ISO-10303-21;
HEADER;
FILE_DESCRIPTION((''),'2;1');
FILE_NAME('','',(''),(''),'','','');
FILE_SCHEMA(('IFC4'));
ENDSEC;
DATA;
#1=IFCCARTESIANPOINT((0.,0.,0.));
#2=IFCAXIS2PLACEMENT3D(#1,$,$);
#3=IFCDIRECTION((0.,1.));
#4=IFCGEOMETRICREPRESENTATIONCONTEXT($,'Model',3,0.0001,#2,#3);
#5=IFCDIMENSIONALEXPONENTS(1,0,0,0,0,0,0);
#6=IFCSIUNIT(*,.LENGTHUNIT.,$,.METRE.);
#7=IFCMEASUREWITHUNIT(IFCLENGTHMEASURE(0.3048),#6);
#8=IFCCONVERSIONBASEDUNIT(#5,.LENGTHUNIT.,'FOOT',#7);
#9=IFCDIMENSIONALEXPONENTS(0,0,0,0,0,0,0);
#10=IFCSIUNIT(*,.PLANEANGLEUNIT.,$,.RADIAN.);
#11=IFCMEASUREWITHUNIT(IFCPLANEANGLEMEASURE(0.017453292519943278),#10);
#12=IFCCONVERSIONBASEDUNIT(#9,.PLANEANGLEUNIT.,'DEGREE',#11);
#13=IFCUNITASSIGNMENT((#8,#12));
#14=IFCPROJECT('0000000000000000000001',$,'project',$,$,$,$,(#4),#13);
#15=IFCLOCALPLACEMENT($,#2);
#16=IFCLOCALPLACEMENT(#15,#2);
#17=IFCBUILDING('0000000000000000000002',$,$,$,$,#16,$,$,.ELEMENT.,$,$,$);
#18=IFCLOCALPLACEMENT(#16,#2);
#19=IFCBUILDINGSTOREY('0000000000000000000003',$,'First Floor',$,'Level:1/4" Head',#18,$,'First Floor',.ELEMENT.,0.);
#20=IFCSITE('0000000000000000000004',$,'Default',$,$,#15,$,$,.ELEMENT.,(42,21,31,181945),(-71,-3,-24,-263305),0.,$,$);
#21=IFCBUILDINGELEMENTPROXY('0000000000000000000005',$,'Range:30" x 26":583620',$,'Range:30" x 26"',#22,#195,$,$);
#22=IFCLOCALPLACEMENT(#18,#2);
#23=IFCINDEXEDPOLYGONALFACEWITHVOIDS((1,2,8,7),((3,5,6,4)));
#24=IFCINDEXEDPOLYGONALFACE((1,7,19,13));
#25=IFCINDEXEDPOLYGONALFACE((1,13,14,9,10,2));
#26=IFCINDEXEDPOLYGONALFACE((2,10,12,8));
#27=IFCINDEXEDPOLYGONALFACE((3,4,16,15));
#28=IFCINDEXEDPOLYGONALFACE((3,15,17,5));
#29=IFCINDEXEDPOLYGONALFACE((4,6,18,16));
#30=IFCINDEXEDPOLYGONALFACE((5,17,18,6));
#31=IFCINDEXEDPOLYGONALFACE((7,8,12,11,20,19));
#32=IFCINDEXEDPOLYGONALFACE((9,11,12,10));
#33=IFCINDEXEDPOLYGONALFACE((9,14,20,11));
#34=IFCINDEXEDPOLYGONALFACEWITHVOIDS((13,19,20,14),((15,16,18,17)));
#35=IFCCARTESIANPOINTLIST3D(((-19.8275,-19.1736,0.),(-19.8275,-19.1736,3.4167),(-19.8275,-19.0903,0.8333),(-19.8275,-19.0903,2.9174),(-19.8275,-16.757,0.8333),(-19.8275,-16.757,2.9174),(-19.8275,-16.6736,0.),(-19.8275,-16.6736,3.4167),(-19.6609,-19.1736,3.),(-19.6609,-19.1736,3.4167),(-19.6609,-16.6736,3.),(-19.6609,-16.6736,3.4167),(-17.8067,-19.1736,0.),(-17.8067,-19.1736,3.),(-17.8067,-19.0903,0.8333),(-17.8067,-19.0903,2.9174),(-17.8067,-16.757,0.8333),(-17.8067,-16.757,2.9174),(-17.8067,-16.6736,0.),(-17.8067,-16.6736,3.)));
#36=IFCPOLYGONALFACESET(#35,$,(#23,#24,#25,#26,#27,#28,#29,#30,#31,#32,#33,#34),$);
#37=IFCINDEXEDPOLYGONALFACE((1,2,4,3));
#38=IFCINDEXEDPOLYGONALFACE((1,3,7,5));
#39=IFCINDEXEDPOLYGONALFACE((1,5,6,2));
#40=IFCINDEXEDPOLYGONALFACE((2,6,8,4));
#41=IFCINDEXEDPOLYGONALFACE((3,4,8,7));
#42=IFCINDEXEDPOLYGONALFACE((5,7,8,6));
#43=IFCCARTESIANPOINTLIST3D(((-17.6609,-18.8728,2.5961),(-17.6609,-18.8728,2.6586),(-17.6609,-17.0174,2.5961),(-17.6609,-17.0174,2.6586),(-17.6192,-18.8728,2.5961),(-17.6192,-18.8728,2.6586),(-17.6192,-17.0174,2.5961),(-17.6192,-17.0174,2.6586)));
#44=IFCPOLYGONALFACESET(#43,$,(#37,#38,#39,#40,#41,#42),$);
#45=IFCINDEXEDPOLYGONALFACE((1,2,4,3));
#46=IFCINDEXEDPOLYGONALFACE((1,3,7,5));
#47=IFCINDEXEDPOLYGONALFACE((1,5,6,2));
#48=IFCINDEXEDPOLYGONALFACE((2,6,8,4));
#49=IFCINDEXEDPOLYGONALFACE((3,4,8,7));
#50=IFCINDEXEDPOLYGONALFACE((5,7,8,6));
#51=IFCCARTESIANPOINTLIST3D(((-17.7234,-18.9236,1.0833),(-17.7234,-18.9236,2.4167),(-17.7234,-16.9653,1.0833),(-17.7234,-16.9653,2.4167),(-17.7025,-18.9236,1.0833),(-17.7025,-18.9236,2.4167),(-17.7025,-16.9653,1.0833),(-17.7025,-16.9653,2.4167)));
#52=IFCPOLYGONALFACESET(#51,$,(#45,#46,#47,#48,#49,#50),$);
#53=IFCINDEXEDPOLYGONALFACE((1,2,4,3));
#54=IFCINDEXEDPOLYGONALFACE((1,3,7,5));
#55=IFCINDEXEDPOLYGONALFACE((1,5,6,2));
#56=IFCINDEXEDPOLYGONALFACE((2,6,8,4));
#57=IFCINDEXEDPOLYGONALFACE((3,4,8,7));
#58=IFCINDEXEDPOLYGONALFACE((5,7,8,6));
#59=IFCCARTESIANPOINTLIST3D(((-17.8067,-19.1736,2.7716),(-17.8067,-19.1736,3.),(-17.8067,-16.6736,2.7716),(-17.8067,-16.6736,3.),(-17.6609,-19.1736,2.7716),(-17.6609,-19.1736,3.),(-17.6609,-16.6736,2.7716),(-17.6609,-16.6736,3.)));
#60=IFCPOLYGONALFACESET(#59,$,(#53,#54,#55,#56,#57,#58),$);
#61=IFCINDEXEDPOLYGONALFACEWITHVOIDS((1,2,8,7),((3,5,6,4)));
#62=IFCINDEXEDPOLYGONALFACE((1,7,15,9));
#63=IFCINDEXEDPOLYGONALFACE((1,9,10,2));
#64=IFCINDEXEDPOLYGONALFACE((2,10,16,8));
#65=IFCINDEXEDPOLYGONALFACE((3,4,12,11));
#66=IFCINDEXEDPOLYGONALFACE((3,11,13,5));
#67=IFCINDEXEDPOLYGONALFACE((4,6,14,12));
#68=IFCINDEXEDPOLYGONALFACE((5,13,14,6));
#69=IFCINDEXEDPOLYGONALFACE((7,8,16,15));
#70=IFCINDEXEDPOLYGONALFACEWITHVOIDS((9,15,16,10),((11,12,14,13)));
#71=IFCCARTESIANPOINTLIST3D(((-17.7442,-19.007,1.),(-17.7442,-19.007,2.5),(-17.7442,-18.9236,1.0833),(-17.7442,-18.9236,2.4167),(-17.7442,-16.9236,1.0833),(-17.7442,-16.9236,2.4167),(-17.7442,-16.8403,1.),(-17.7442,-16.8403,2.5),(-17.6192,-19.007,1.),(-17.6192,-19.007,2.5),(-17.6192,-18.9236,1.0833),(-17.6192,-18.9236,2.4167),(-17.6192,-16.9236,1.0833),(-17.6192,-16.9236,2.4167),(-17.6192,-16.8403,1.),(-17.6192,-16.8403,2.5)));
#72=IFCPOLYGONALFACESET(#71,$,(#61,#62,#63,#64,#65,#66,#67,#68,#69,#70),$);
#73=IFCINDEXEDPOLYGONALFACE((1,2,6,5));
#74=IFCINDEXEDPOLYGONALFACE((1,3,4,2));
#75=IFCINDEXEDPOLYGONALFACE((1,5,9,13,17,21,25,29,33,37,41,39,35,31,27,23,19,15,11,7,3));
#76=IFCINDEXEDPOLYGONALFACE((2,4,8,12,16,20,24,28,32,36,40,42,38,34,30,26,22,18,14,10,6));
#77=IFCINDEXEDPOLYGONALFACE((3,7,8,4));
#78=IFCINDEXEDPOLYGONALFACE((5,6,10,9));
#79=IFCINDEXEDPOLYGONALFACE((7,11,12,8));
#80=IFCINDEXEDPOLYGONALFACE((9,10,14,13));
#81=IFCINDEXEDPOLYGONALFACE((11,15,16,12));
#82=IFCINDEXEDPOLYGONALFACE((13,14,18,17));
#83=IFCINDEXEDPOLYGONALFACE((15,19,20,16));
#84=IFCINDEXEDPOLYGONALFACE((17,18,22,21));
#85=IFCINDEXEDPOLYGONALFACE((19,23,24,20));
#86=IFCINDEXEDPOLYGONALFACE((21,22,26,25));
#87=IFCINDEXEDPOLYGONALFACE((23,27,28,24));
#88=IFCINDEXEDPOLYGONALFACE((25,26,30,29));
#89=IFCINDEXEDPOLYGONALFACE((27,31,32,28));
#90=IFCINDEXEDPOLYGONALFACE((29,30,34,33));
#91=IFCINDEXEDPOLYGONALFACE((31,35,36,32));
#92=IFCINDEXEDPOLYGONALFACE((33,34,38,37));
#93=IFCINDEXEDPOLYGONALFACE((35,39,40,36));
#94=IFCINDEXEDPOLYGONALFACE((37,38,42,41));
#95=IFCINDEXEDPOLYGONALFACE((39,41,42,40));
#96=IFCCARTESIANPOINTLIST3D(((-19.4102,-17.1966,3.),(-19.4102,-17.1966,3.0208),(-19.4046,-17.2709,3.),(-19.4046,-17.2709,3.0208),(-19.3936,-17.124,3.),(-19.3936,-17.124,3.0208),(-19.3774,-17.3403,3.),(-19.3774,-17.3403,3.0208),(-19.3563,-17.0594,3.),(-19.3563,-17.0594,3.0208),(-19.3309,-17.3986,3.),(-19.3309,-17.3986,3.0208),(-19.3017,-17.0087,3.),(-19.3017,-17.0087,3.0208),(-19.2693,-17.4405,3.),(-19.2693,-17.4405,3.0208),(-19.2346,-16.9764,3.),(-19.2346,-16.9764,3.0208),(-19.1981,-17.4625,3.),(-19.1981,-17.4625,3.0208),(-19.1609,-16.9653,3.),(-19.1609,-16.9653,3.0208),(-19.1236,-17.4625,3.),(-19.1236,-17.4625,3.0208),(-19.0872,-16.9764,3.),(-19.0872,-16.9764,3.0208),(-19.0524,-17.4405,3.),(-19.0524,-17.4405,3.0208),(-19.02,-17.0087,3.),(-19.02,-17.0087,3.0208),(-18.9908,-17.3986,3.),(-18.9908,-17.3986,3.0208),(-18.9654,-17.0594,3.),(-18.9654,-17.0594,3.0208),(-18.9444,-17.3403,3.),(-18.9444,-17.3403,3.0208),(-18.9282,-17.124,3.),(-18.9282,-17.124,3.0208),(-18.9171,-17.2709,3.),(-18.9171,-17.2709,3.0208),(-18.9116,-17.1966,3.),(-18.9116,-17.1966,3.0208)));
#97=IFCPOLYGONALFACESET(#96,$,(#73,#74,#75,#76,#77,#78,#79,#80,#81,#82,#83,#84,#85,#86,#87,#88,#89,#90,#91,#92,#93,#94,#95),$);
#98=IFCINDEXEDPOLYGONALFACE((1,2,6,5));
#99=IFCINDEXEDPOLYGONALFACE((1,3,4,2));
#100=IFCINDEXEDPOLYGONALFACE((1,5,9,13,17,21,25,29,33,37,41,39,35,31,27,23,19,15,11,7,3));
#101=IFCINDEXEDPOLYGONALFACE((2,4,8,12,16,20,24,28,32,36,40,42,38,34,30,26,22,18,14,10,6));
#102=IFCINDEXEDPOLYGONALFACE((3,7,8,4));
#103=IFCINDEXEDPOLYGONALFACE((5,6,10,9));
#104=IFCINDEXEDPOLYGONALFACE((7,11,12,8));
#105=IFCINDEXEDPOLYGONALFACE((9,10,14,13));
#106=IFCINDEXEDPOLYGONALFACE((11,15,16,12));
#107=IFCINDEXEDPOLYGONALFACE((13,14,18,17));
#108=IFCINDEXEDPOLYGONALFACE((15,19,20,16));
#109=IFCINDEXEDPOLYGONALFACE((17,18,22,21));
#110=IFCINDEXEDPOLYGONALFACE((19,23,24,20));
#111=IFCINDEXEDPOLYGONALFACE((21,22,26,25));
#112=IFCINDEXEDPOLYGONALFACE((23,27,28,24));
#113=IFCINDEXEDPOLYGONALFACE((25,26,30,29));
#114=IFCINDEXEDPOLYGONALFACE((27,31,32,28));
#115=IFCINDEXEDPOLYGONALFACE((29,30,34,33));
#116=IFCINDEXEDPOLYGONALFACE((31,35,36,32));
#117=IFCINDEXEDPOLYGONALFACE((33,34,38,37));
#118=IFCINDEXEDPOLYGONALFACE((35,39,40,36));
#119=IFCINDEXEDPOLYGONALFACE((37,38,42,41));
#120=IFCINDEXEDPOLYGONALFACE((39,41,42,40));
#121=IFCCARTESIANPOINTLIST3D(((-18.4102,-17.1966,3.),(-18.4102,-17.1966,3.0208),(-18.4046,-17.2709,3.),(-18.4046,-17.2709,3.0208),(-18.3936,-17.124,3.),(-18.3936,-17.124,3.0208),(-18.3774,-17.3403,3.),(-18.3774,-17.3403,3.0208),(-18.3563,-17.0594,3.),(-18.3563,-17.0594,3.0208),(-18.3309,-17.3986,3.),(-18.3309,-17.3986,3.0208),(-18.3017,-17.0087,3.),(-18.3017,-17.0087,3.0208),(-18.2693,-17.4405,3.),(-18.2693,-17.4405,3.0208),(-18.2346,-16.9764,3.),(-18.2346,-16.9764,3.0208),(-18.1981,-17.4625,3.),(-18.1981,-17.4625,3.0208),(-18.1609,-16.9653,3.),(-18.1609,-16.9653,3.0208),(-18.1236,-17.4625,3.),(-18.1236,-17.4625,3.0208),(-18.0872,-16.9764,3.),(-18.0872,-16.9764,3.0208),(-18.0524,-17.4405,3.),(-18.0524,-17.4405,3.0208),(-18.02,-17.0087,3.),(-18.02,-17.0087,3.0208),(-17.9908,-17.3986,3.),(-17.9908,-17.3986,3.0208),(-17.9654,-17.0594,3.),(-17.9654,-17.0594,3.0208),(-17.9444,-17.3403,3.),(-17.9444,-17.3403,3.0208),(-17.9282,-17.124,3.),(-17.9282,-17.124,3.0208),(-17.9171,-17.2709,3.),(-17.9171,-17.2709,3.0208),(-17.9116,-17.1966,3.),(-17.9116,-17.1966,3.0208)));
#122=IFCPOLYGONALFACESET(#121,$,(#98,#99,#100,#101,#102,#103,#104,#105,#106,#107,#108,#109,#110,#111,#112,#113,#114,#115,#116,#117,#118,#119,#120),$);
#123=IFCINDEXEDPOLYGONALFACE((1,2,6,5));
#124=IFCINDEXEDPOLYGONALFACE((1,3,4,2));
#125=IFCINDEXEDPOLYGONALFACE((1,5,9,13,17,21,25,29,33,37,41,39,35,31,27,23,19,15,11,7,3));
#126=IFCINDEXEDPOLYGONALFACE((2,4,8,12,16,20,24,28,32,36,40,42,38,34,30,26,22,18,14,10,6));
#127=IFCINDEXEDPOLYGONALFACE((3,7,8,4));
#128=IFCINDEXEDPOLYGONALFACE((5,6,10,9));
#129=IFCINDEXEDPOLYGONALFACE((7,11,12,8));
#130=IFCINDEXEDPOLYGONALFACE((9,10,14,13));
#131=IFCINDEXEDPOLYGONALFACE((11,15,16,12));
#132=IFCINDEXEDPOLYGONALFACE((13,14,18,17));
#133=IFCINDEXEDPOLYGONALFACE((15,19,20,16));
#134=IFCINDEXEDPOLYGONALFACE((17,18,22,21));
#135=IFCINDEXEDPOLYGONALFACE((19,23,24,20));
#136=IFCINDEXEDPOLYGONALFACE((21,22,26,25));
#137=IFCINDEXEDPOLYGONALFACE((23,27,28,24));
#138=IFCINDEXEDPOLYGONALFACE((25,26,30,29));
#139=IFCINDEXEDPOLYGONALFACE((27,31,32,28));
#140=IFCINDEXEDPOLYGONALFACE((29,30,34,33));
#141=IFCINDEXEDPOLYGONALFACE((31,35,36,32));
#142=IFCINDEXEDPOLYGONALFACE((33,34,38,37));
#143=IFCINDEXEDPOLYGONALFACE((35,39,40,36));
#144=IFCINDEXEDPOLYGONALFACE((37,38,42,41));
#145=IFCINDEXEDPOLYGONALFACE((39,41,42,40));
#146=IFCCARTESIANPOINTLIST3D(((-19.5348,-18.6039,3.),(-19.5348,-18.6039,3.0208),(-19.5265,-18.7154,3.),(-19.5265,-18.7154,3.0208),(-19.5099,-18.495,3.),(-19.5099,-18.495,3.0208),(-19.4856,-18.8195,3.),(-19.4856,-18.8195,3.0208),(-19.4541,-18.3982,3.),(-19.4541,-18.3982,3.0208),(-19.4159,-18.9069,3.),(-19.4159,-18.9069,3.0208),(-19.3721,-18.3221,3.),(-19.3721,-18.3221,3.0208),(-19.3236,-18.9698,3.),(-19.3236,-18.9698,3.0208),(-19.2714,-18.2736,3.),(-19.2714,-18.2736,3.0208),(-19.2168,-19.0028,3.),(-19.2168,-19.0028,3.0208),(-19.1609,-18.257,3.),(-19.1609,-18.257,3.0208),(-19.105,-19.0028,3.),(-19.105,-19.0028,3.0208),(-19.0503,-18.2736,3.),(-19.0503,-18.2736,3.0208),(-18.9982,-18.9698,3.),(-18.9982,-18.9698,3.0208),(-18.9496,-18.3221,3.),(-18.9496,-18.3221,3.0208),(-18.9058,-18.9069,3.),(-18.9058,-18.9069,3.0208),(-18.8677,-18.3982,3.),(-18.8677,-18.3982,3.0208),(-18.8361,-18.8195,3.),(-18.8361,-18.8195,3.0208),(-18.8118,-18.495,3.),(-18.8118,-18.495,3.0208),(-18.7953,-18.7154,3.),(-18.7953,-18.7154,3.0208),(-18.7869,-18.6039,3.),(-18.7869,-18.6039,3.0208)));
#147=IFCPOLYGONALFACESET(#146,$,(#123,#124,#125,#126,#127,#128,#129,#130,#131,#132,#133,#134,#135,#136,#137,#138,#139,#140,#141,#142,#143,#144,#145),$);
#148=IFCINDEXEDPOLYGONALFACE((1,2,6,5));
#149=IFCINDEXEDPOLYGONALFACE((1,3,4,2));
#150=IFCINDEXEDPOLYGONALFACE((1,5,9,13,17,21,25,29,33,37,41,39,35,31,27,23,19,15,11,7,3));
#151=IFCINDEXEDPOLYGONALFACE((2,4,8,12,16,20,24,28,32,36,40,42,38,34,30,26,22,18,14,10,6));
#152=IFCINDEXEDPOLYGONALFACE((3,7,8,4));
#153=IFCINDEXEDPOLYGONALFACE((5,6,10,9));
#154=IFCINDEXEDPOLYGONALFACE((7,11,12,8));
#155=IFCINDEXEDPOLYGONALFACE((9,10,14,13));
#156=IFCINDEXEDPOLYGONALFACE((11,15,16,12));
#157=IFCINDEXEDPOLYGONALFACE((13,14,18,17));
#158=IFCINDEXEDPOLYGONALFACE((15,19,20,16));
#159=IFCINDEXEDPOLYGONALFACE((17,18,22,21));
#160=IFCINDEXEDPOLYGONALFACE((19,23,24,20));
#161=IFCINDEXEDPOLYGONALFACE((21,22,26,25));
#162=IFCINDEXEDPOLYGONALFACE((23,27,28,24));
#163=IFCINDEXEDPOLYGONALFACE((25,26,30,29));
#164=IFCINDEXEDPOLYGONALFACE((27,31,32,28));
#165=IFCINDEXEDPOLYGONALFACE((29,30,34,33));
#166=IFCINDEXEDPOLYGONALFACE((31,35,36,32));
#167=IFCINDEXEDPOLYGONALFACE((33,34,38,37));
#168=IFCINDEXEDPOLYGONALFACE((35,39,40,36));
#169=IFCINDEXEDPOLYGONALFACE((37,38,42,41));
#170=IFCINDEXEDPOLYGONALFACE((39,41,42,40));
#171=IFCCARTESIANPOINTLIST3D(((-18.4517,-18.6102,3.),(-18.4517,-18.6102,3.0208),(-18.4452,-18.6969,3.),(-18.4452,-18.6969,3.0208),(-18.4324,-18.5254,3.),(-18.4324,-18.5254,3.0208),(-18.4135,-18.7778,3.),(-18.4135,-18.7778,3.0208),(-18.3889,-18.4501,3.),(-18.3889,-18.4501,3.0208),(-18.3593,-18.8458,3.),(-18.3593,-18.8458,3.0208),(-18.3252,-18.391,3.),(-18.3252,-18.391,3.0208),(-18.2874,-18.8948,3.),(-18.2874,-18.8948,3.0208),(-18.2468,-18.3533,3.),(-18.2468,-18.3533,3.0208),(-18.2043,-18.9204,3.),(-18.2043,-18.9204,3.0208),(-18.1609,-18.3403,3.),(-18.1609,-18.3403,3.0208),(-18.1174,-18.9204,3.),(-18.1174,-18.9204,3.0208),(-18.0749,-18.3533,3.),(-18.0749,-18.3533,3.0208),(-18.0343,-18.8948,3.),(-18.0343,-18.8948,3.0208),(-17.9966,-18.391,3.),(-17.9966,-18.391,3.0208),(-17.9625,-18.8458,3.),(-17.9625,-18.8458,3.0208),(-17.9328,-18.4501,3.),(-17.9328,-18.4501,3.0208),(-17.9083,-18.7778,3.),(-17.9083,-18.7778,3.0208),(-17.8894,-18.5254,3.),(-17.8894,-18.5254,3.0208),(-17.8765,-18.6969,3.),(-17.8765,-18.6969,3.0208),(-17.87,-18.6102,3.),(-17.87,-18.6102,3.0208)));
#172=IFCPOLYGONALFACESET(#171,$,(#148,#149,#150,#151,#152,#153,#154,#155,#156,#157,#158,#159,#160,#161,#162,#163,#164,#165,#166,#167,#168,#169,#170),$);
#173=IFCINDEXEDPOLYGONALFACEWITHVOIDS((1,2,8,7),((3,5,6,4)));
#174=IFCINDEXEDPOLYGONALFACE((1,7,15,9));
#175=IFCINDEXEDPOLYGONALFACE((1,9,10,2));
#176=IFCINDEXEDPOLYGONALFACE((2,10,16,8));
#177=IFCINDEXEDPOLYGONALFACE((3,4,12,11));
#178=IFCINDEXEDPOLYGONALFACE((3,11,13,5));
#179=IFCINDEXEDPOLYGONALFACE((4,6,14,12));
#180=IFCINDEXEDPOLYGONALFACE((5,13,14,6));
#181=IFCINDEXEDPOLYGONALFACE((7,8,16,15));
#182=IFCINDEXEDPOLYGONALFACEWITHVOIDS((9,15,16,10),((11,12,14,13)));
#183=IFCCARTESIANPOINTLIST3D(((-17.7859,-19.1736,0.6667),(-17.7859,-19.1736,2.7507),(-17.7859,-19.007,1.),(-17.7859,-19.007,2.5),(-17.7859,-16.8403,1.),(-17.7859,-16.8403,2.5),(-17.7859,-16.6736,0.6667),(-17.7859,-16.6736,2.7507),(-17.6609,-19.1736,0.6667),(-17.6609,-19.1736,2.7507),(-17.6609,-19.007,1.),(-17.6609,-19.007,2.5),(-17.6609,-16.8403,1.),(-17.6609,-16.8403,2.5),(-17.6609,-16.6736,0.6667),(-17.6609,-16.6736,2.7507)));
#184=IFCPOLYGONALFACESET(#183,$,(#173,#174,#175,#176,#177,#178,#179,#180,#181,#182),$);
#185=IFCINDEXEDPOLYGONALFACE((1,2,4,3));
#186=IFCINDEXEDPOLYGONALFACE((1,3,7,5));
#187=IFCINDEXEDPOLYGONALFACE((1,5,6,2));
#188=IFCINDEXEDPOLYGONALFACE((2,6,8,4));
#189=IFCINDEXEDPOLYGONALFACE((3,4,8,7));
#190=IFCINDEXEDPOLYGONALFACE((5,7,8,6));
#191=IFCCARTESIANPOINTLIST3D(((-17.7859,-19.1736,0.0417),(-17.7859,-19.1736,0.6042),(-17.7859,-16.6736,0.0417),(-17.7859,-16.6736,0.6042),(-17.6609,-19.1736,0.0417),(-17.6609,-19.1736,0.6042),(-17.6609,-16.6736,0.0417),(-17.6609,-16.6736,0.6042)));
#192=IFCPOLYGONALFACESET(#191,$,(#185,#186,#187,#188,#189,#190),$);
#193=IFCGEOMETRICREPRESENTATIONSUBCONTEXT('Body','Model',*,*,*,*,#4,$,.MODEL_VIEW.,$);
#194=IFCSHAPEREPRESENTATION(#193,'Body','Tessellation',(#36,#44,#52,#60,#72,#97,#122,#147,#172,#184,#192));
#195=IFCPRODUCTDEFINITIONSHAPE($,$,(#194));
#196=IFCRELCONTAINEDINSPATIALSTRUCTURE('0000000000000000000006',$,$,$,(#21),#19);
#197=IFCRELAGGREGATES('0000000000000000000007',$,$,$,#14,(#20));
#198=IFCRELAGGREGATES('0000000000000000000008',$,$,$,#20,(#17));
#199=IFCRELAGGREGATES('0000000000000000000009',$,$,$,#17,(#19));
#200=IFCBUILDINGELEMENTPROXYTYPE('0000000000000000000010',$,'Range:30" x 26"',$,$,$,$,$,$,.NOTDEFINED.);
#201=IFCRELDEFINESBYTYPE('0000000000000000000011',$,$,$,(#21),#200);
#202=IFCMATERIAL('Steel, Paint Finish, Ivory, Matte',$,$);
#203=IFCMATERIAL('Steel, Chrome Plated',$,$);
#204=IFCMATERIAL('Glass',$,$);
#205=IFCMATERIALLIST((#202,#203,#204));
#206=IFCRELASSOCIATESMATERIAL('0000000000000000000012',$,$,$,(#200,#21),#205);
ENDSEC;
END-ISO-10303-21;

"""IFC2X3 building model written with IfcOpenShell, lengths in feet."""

from ifc_helpers import new_model, entity, si_unit, converted_unit, direction, frame, frame_2d, origin, origin_2d_with_axis, place, context, subcontext, project, spatial, polyline, rectangle, circle, outline, extrude, source, transform, mapped, material, material_list, type_object, type_shapes, element, save


model = new_model("IFC2X3")

# Units and contexts
model_context = context("Model", 3, precision=0.0001, world=origin(), true_north=direction((0.0, 1.0)))
body_context = subcontext(model_context, "Body", "Model", "MODEL_VIEW")
ifc_project = project(units=[converted_unit("LENGTHUNIT", "FOOT", entity("IfcLengthMeasure", 0.3048), si_unit("LENGTHUNIT", "METRE"), dimensions=[1, 0, 0, 0, 0, 0, 0]), converted_unit("PLANEANGLEUNIT", "DEGREE", entity("IfcPlaneAngleMeasure", 0.017453292519943278), si_unit("PLANEANGLEUNIT", "RADIAN"), dimensions=[0, 0, 0, 0, 0, 0, 0])], contexts=[model_context])

# Site, building, storey
site_placement = place(None, origin())
site = spatial("IfcSite", under=ifc_project, at=site_placement, Name="Default", CompositionType="ELEMENT", RefLatitude=(42, 21, 31, 181945), RefLongitude=(-71, -3, -24, -263305), RefElevation=0.0)
building_placement = place(site_placement, origin())
building = spatial("IfcBuilding", under=site, at=building_placement, CompositionType="ELEMENT")
storey_placement = place(building_placement, origin())
storey = spatial("IfcBuildingStorey", under=building, at=storey_placement, Name="First Floor", ObjectType="Level:1/4\" Head", LongName="First Floor", CompositionType="ELEMENT", Elevation=0.0)

# Shared definitions
ifc_material_1 = material(Name="Steel, Chrome Plated")

# Building element proxy, opening
ifc_material_2 = material(Name="Steel, Paint Finish, Ivory, Matte")
ifc_material_3 = material(Name="Glass")
ifc_material_list_1 = material_list([ifc_material_2, ifc_material_1, ifc_material_3])
building_element_proxy_type_1 = type_object("IfcBuildingElementProxyType", Name="Range:30\" x 26\"", PredefinedType="NOTDEFINED", material=ifc_material_list_1)
shared_shape_1 = source(origin(), body_context, "Body", "SweptSolid", [
    extrude(outline(polyline([(-0.7292, -1.2778), (-0.5625, -1.2778), (-0.5625, -0.8611), (1.2917, -0.8611), (1.2917, 2.1389), (-0.7292, 2.1389), (-0.7292, -1.2778)])), frame((0.0, 1.4375, 2.1389), z_axis=(1.0, 0.0, 0.0), x_axis=(0.0, -1.0, 0.0)), (0.0, 0.0, 1.0), 2.5),
    extrude(rectangle(XDim=0.0417, YDim=1.8554, at=origin_2d_with_axis()), frame((1.2285, -0.0208, 2.5961), z_axis=(0.0, 0.0, 1.0), x_axis=(0.0, 1.0, 0.0)), (0.0, 0.0, 1.0), 0.0625),
    extrude(rectangle(XDim=0.0208, YDim=1.9583, at=frame_2d((0.0, 0.0), x_axis=(1.0, 0.0))), frame((1.2292, 0.0521, 1.0833), z_axis=(0.0, 0.0, 1.0), x_axis=(0.0, 1.0, 0.0)), (0.0, 0.0, 1.0), 1.3333),
    extrude(rectangle(XDim=0.1458, YDim=2.5, at=origin_2d_with_axis()), frame((1.25, 0.0729, 2.7716), z_axis=(0.0, 0.0, 1.0), x_axis=(0.0, 1.0, 0.0)), (0.0, 0.0, 1.0), 0.2284),
    extrude(outline(polyline([(-0.75, -1.0833), (0.75, -1.0833), (0.75, 1.0833), (-0.75, 1.0833), (-0.75, -1.0833)]), holes=[polyline([(-0.6667, -1.0), (-0.6667, 1.0), (0.6667, 1.0), (0.6667, -1.0), (-0.6667, -1.0)])]), frame((1.25, -0.0417, 1.75), z_axis=(0.0, 1.0, 0.0), x_axis=(0.0, 0.0, -1.0)), (0.0, 0.0, 1.0), 0.125),
    extrude(circle(Radius=0.25, at=frame_2d((0.0, 0.0), x_axis=(1.0, 0.0))), frame((1.9583, 1.5, 3.0)), (0.0, 0.0, 1.0), 0.0208),
    extrude(circle(Radius=0.25, at=frame_2d((0.0, 0.0), x_axis=(1.0, 0.0))), frame((1.9583, 0.5, 3.0)), (0.0, 0.0, 1.0), 0.0208),
    extrude(circle(Radius=0.375, at=frame_2d((0.0, 0.0), x_axis=(1.0, 0.0))), frame((0.5417, 1.5, 3.0)), (0.0, 0.0, 1.0), 0.0208),
    extrude(circle(Radius=0.2917, at=frame_2d((0.0, 0.0), x_axis=(1.0, 0.0))), frame((0.5417, 0.5, 3.0)), (0.0, 0.0, 1.0), 0.0208),
    extrude(rectangle(XDim=0.0833, YDim=2.3333, at=frame_2d((0.0, 0.0), x_axis=(1.0, 0.0))), frame((1.25, 2.125, 0.8333), z_axis=(0.0, 0.0, 1.0), x_axis=(0.0, -1.0, 0.0)), (0.0, 0.0, 1.0), 2.0841),
    extrude(outline(polyline([(-1.042, -1.25), (1.042, -1.25), (1.042, 1.25), (-1.042, 1.25), (-1.042, -1.25)]), holes=[polyline([(-0.7913, -1.0833), (-0.7913, 1.0833), (0.7087, 1.0833), (0.7087, -1.0833), (-0.7913, -1.0833)])]), frame((1.25, 0.0, 1.7087), z_axis=(0.0, 1.0, 0.0), x_axis=(0.0, 0.0, -1.0)), (0.0, 0.0, 1.0), 0.125),
    extrude(rectangle(XDim=0.125, YDim=2.5, at=origin_2d_with_axis()), frame((1.25, 0.0625, 0.0417), z_axis=(0.0, 0.0, 1.0), x_axis=(0.0, 1.0, 0.0)), (0.0, 0.0, 1.0), 0.5625),
])
type_shapes(building_element_proxy_type_1, [shared_shape_1])
proxy_1_placement = place(storey_placement, frame((-17.6609, -19.1736, 0.0), z_axis=(0.0, 0.0, 1.0), x_axis=(0.0, 1.0, 0.0)))
proxy_1 = element("IfcBuildingElementProxy", 1, at=proxy_1_placement, inside=storey, type_object=building_element_proxy_type_1, material=ifc_material_list_1, Name="Range:30\" x 26\":583620", ObjectType="Range:30\" x 26\"", context=body_context, shape_type="MappedRepresentation", body=[
    mapped(shared_shape_1, transform((0.0, 0.0, 0.0), scale=1.0)),
])
opening_1_placement = place(storey_placement, frame((-17.6609, -19.1736, 0.0), z_axis=(0.0, 0.0, 1.0), x_axis=(-1.0, 0.0, 0.0)))
element("IfcOpeningElement", 2, at=opening_1_placement, cuts=proxy_1, ObjectType="Opening", context=body_context, shape_type="SweptSolid", body=[
    extrude(rectangle(XDim=2.0841, YDim=2.3333, at=frame_2d((0.0, 0.0), x_axis=(1.0, 0.0))), frame((0.1458, -1.25, 1.8754), z_axis=(1.0, 0.0, 0.0), x_axis=(0.0, 0.0, -1.0)), (0.0, 0.0, 1.0), 2.0208),
])

save(model, "model.ifc")
